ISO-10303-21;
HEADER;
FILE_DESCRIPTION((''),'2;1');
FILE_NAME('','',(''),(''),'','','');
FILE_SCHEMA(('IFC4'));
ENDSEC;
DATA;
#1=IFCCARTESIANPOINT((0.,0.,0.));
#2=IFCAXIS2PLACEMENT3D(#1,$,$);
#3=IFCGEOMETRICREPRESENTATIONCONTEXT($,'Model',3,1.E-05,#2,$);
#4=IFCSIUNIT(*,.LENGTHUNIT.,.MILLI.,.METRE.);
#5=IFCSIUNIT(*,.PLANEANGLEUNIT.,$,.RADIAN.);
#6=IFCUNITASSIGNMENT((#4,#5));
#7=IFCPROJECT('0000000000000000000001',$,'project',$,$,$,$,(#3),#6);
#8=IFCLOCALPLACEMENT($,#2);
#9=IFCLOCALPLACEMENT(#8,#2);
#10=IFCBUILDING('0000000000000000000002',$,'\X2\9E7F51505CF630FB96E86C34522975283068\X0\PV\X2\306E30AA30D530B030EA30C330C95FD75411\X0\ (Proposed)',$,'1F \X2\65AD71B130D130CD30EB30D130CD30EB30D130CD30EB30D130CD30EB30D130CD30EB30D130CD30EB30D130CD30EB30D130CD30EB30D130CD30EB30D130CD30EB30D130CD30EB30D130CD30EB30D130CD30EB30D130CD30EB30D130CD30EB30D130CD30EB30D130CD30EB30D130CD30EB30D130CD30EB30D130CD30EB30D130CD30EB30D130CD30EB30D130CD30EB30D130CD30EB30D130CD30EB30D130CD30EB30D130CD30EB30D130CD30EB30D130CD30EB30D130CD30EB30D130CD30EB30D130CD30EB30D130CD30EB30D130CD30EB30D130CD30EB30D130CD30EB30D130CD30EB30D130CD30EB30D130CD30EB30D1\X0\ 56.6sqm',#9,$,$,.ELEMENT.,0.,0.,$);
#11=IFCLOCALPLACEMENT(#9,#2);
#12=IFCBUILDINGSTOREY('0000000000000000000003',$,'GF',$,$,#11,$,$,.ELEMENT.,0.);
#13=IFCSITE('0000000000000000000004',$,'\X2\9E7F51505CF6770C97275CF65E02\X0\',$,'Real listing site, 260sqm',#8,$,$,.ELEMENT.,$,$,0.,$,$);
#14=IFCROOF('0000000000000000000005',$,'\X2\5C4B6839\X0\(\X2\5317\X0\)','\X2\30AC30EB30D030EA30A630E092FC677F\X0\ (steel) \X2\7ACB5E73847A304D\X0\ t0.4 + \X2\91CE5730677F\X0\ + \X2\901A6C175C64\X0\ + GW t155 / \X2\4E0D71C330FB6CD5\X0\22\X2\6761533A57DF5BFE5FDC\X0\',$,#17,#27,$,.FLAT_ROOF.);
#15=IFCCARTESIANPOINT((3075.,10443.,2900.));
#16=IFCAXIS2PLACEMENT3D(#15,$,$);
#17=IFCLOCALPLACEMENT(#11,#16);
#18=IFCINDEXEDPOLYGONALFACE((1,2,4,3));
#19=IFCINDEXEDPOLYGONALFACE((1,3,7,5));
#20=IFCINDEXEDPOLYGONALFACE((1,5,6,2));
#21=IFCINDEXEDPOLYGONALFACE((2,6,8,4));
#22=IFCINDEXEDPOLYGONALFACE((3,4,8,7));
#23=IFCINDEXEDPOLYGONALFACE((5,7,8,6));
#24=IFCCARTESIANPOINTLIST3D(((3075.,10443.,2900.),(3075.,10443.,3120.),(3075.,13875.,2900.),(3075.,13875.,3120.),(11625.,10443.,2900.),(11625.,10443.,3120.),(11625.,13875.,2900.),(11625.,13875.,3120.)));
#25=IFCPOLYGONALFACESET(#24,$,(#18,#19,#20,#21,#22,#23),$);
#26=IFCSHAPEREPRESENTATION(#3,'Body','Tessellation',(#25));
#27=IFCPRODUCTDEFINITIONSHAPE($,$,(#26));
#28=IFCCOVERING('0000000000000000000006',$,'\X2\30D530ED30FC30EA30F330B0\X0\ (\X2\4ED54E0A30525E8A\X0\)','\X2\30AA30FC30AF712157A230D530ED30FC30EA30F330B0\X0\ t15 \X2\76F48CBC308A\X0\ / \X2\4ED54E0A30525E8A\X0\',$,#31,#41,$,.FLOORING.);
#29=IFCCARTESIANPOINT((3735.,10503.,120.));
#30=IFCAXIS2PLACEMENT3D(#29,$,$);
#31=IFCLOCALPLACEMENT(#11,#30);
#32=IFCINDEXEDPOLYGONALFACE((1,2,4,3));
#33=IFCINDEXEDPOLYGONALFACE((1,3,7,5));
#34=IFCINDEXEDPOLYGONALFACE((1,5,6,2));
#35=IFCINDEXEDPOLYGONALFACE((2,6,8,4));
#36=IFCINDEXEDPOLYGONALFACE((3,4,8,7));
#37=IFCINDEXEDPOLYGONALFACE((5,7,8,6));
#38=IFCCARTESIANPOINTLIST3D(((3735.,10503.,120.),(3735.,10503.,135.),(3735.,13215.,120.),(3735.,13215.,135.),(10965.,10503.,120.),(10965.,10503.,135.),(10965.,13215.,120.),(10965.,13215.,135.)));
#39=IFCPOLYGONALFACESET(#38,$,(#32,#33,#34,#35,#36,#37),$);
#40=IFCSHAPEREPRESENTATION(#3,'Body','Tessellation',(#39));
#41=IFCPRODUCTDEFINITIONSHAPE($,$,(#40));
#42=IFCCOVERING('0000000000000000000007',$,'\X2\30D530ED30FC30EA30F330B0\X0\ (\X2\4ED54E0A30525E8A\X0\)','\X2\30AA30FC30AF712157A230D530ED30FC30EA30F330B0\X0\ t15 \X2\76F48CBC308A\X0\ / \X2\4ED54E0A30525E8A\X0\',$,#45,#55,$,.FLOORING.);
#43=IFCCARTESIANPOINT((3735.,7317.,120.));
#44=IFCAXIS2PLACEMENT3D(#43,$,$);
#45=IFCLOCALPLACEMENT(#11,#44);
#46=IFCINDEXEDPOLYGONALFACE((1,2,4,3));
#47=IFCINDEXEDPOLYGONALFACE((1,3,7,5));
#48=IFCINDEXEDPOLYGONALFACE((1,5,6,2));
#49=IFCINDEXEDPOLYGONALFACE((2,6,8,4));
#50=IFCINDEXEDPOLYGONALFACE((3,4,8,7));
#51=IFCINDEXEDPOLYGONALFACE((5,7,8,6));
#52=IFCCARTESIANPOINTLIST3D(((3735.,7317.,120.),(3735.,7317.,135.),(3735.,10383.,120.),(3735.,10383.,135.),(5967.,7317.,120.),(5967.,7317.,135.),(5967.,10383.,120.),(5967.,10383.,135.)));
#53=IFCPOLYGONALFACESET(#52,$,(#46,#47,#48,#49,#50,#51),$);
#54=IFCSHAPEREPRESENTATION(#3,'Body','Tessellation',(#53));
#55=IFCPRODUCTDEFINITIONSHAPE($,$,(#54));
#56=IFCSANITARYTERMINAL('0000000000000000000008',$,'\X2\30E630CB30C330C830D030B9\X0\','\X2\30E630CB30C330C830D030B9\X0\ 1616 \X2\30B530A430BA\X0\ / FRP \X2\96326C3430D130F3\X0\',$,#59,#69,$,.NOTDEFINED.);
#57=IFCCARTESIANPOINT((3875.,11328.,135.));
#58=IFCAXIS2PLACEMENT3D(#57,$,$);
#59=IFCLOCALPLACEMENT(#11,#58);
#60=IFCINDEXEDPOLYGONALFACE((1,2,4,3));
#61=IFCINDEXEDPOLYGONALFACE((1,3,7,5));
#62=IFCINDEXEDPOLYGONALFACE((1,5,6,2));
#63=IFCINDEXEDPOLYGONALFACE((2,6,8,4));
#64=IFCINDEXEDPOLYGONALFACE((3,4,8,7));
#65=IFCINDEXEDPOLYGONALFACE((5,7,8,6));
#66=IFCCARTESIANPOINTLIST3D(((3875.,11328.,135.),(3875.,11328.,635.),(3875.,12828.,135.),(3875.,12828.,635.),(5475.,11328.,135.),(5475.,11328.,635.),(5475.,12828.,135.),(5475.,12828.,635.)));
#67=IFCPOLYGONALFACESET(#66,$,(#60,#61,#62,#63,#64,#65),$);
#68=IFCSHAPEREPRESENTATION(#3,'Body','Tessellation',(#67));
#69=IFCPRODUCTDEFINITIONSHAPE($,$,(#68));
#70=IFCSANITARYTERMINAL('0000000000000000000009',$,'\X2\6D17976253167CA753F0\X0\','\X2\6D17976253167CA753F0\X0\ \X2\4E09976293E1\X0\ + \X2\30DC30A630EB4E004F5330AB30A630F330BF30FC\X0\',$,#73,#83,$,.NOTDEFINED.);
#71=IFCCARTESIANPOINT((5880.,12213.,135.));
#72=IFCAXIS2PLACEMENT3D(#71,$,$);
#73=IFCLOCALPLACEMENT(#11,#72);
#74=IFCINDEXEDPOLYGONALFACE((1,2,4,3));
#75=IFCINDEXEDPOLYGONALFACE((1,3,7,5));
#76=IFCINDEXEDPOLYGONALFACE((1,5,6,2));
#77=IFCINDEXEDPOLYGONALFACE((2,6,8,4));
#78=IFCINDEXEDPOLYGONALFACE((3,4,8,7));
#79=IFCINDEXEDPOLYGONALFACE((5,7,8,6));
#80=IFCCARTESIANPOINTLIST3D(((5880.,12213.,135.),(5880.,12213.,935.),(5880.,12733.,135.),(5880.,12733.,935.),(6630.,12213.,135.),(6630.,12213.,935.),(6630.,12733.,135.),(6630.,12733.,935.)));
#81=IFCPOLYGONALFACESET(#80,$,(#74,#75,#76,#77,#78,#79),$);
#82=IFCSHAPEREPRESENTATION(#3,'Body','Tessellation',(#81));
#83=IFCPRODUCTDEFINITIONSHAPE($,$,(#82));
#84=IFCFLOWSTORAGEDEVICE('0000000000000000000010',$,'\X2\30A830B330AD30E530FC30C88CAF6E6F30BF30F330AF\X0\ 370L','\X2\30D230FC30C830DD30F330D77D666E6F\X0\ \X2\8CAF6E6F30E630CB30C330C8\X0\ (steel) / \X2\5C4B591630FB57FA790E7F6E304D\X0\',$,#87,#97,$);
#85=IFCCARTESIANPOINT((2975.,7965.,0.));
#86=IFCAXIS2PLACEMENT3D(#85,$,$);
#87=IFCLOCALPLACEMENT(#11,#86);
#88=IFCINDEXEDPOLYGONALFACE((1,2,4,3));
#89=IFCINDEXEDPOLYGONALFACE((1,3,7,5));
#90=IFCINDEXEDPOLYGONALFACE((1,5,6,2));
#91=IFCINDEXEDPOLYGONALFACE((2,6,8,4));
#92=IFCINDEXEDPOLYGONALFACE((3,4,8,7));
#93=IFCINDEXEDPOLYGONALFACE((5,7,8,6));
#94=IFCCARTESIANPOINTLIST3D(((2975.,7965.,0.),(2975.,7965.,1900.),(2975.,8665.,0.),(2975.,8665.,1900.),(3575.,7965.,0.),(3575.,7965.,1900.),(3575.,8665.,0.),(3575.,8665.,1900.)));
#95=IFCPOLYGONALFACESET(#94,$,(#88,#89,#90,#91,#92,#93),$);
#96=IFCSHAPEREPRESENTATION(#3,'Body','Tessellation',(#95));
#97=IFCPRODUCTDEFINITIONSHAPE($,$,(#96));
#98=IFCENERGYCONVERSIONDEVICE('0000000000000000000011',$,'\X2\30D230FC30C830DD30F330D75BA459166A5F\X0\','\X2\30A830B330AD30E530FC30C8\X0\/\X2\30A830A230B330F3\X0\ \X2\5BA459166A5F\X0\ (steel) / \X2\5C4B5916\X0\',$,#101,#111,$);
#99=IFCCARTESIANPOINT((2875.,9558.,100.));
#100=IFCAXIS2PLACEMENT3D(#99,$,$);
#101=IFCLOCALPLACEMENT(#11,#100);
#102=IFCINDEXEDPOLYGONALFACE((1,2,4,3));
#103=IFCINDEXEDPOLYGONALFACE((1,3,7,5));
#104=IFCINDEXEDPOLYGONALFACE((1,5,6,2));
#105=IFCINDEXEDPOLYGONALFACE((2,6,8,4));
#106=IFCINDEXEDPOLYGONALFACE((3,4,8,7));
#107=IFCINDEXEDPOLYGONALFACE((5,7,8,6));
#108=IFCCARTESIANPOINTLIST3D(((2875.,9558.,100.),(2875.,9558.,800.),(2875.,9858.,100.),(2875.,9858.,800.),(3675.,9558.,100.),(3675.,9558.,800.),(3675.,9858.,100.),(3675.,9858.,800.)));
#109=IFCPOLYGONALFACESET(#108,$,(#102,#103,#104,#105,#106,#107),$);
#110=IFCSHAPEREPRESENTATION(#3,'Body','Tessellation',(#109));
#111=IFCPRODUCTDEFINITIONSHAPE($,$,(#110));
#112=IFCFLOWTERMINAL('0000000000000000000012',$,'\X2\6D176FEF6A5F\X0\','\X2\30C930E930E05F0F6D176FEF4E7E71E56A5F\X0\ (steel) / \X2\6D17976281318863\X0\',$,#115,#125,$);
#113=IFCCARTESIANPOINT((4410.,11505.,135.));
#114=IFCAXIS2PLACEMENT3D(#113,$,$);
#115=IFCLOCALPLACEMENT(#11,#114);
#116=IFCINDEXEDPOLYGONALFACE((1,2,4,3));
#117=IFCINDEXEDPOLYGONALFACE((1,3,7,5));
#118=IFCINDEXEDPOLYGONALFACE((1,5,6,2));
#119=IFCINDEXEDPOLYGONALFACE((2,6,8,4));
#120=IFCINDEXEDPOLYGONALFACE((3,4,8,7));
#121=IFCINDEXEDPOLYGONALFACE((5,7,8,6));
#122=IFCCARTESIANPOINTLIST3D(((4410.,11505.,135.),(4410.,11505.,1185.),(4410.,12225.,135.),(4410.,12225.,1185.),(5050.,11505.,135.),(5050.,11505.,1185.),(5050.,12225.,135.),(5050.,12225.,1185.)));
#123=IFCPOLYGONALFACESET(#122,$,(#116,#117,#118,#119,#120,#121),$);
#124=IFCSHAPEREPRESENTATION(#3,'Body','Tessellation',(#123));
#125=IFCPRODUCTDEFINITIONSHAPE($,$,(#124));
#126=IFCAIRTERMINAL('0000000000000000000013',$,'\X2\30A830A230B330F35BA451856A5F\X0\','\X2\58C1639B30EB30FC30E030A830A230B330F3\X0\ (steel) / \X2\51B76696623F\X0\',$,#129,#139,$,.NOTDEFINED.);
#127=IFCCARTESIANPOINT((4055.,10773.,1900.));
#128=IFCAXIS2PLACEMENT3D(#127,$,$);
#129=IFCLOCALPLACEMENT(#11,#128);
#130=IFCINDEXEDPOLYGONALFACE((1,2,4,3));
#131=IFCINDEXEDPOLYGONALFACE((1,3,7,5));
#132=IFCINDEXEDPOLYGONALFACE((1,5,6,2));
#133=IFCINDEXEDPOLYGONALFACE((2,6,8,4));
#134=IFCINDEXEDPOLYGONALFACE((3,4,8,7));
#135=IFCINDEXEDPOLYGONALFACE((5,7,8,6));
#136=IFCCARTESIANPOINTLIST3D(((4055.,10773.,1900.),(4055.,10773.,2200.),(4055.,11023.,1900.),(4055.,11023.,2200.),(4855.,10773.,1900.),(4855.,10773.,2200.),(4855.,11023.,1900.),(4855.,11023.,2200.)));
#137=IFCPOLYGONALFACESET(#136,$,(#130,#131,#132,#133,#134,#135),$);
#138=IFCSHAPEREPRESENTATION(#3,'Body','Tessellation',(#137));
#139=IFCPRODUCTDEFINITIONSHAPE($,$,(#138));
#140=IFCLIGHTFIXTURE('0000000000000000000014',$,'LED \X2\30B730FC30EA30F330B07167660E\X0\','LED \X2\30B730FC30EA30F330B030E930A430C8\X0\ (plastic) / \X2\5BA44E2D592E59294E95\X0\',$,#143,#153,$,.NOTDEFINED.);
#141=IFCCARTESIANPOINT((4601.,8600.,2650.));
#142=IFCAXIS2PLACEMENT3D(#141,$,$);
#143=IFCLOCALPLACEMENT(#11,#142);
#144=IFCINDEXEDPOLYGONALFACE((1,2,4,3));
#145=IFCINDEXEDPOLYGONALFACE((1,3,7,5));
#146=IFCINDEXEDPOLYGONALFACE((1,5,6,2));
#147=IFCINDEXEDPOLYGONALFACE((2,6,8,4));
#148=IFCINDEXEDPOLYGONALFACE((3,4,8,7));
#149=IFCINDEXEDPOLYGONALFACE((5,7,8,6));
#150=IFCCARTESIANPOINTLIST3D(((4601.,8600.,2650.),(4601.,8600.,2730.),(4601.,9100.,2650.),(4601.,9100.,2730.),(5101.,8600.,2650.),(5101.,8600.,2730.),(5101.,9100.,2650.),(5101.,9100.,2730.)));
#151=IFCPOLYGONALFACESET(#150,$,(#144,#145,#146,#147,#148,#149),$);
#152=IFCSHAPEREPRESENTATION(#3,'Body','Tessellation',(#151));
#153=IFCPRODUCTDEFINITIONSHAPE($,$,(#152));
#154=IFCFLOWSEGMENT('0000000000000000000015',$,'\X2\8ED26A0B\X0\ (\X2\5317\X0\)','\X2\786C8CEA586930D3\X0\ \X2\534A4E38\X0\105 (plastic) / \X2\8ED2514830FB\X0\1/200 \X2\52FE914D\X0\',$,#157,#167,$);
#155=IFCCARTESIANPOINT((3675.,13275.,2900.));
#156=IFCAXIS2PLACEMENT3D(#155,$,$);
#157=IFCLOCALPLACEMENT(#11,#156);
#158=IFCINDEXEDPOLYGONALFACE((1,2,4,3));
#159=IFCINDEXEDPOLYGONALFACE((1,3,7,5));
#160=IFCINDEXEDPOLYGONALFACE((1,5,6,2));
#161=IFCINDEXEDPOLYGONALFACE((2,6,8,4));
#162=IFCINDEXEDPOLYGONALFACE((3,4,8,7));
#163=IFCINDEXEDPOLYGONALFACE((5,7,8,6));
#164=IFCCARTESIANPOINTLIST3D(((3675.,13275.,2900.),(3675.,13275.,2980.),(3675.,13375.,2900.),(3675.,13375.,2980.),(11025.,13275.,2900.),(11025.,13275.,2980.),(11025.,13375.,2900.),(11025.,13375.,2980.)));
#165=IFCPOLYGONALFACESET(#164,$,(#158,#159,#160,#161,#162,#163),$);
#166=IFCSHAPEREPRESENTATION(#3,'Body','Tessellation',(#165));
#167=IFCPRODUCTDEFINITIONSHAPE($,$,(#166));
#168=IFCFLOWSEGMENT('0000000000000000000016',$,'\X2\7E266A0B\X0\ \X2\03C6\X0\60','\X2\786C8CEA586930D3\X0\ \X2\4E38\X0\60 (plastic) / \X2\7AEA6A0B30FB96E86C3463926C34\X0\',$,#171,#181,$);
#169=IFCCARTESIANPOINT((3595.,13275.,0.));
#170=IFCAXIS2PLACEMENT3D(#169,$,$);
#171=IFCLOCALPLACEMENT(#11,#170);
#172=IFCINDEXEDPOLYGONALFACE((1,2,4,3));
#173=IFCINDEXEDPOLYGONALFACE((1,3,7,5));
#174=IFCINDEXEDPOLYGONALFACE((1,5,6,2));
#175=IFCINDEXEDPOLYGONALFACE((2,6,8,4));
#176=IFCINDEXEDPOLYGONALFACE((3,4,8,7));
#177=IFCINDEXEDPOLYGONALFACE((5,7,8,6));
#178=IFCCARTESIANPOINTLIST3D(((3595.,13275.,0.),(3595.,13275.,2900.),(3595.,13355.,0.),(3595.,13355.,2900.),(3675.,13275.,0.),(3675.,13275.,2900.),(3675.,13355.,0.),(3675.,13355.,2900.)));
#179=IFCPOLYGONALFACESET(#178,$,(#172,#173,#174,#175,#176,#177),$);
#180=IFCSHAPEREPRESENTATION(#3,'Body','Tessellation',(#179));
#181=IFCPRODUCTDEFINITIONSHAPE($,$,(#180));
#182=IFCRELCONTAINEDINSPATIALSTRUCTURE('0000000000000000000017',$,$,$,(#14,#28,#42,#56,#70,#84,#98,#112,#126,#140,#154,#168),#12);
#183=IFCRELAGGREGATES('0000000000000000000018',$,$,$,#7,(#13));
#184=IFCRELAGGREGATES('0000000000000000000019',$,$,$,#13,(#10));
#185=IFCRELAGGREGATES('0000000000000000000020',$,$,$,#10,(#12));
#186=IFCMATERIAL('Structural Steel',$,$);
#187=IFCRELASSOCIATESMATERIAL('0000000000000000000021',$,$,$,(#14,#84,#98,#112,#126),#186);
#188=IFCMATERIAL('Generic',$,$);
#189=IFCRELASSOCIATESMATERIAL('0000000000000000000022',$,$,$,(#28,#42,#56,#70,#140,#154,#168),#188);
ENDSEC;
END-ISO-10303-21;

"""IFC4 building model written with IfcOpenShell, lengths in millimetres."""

from ifc_helpers import new_model, si_unit, frame, frame_2d, origin, place, context, project, spatial, rectangle, extrude, material, element, save


model = new_model("IFC4")

# Units and contexts
model_context = context("Model", 3, precision=1e-05, world=origin())
ifc_project = project(units=[si_unit("LENGTHUNIT", "METRE", prefix="MILLI"), si_unit("PLANEANGLEUNIT", "RADIAN")], contexts=[model_context])

# Site, building, storey
site_placement = place(None, origin())
site = spatial("IfcSite", under=ifc_project, at=site_placement, Name="鹿児島県霧島市", ObjectType="Real listing site, 260sqm", CompositionType="ELEMENT", RefElevation=0.0)
building_placement = place(site_placement, origin())
building = spatial("IfcBuilding", under=site, at=building_placement, Name="鹿児島・雨水利用とPVのオフグリッド志向 (Proposed)", ObjectType="1F 断熱パネルパネルパネルパネルパネルパネルパネルパネルパネルパネルパネルパネルパネルパネルパネルパネルパネルパネルパネルパネルパネルパネルパネルパネルパネルパネルパネルパネルパネルパネルパネルパネルパネルパネルパネルパネルパネルパネルパネルパ 56.6sqm", CompositionType="ELEMENT", ElevationOfRefHeight=0.0, ElevationOfTerrain=0.0)
storey_placement = place(building_placement, origin())
storey = spatial("IfcBuildingStorey", under=building, at=storey_placement, Name="GF", CompositionType="ELEMENT", Elevation=0.0)

# Roof
ifc_material_1 = material(Name="Structural Steel")
roof_placement = place(storey_placement, frame((3075.0, 10443.0, 2900.0)))
element("IfcRoof", 1, at=roof_placement, inside=storey, material=ifc_material_1, Name="屋根(北)", Description="ガルバリウム鋼板 (steel) 立平葺き t0.4 + 野地板 + 通気層 + GW t155 / 不燃・法22条区域対応", PredefinedType="FLAT_ROOF", context=model_context, shape_type="SweptSolid", body=[
    extrude(rectangle(XDim=8550.0, YDim=3432.0, at=frame_2d((4275.0, 1716.0))), frame((3075.0, 10443.0, 2900.0)), (0.0, 0.0, 1.0), 220.0),
])

# Coverings
ifc_material_2 = material(Name="Generic")
covering_1_placement = place(storey_placement, frame((3735.0, 10503.0, 120.0)))
element("IfcCovering", 2, at=covering_1_placement, inside=storey, material=ifc_material_2, Name="フローリング (仕上げ床)", Description="オーク無垢フローリング t15 直貼り / 仕上げ床", PredefinedType="FLOORING", context=model_context, shape_type="SweptSolid", body=[
    extrude(rectangle(XDim=7230.0, YDim=2712.0, at=frame_2d((3615.0, 1356.0))), frame((3735.0, 10503.0, 120.0)), (0.0, 0.0, 1.0), 15.0),
])
covering_2_placement = place(storey_placement, frame((3735.0, 7317.0, 120.0)))
element("IfcCovering", 3, at=covering_2_placement, inside=storey, material=ifc_material_2, Name="フローリング (仕上げ床)", Description="オーク無垢フローリング t15 直貼り / 仕上げ床", PredefinedType="FLOORING", context=model_context, shape_type="SweptSolid", body=[
    extrude(rectangle(XDim=2232.0, YDim=3066.0, at=frame_2d((1116.0, 1533.0))), frame((3735.0, 7317.0, 120.0)), (0.0, 0.0, 1.0), 15.0),
])

# Sanitary terminals
sanitary_terminal_1_placement = place(storey_placement, frame((3875.0, 11328.0, 135.0)))
element("IfcSanitaryTerminal", 4, at=sanitary_terminal_1_placement, inside=storey, material=ifc_material_2, Name="ユニットバス", Description="ユニットバス 1616 サイズ / FRP 防水パン", PredefinedType="NOTDEFINED", context=model_context, shape_type="SweptSolid", body=[
    extrude(rectangle(XDim=1600.0, YDim=1500.0, at=frame_2d((800.0, 750.0))), frame((3875.0, 11328.0, 135.0)), (0.0, 0.0, 1.0), 500.0),
])
sanitary_terminal_2_placement = place(storey_placement, frame((5880.0, 12213.0, 135.0)))
element("IfcSanitaryTerminal", 5, at=sanitary_terminal_2_placement, inside=storey, material=ifc_material_2, Name="洗面化粧台", Description="洗面化粧台 三面鏡 + ボウル一体カウンター", PredefinedType="NOTDEFINED", context=model_context, shape_type="SweptSolid", body=[
    extrude(rectangle(XDim=750.0, YDim=520.0, at=frame_2d((375.0, 260.0))), frame((5880.0, 12213.0, 135.0)), (0.0, 0.0, 1.0), 800.0),
])

# Flow storage device
flow_storage_device_placement = place(storey_placement, frame((2975.0, 7965.0, 0.0)))
element("IfcFlowStorageDevice", 6, at=flow_storage_device_placement, inside=storey, material=ifc_material_1, Name="エコキュート貯湯タンク 370L", Description="ヒートポンプ給湯 貯湯ユニット (steel) / 屋外・基礎置き", context=model_context, shape_type="SweptSolid", body=[
    extrude(rectangle(XDim=600.0, YDim=700.0, at=frame_2d((300.0, 350.0))), frame((2975.0, 7965.0, 0.0)), (0.0, 0.0, 1.0), 1900.0),
])

# Energy conversion device
energy_conversion_device_placement = place(storey_placement, frame((2875.0, 9558.0, 100.0)))
element("IfcEnergyConversionDevice", 7, at=energy_conversion_device_placement, inside=storey, material=ifc_material_1, Name="ヒートポンプ室外機", Description="エコキュート/エアコン 室外機 (steel) / 屋外", context=model_context, shape_type="SweptSolid", body=[
    extrude(rectangle(XDim=800.0, YDim=300.0, at=frame_2d((400.0, 150.0))), frame((2875.0, 9558.0, 100.0)), (0.0, 0.0, 1.0), 700.0),
])

# Flow terminal
flow_terminal_placement = place(storey_placement, frame((4410.0, 11505.0, 135.0)))
element("IfcFlowTerminal", 8, at=flow_terminal_placement, inside=storey, material=ifc_material_1, Name="洗濯機", Description="ドラム式洗濯乾燥機 (steel) / 洗面脱衣", context=model_context, shape_type="SweptSolid", body=[
    extrude(rectangle(XDim=640.0, YDim=720.0, at=frame_2d((320.0, 360.0))), frame((4410.0, 11505.0, 135.0)), (0.0, 0.0, 1.0), 1050.0),
])

# Air terminal
air_terminal_placement = place(storey_placement, frame((4055.0, 10773.0, 1900.0)))
element("IfcAirTerminal", 9, at=air_terminal_placement, inside=storey, material=ifc_material_1, Name="エアコン室内機", Description="壁掛ルームエアコン (steel) / 冷暖房", PredefinedType="NOTDEFINED", context=model_context, shape_type="SweptSolid", body=[
    extrude(rectangle(XDim=800.0, YDim=250.0, at=frame_2d((400.0, 125.0))), frame((4055.0, 10773.0, 1900.0)), (0.0, 0.0, 1.0), 300.0),
])

# Light fixture
light_fixture_placement = place(storey_placement, frame((4601.0, 8600.0, 2650.0)))
element("IfcLightFixture", 10, at=light_fixture_placement, inside=storey, material=ifc_material_2, Name="LED シーリング照明", Description="LED シーリングライト (plastic) / 室中央天井", PredefinedType="NOTDEFINED", context=model_context, shape_type="SweptSolid", body=[
    extrude(rectangle(XDim=500.0, YDim=500.0, at=frame_2d((250.0, 250.0))), frame((4601.0, 8600.0, 2650.0)), (0.0, 0.0, 1.0), 80.0),
])

# Flow segments
flow_segment_1_placement = place(storey_placement, frame((3675.0, 13275.0, 2900.0)))
element("IfcFlowSegment", 11, at=flow_segment_1_placement, inside=storey, material=ifc_material_2, Name="軒樋 (北)", Description="硬質塩ビ 半丸105 (plastic) / 軒先・1/200 勾配", context=model_context, shape_type="SweptSolid", body=[
    extrude(rectangle(XDim=7350.0, YDim=100.0, at=frame_2d((3675.0, 50.0))), frame((3675.0, 13275.0, 2900.0)), (0.0, 0.0, 1.0), 80.0),
])
flow_segment_2_placement = place(storey_placement, frame((3595.0, 13275.0, 0.0)))
element("IfcFlowSegment", 12, at=flow_segment_2_placement, inside=storey, material=ifc_material_2, Name="縦樋 φ60", Description="硬質塩ビ 丸60 (plastic) / 竪樋・雨水排水", context=model_context, shape_type="SweptSolid", body=[
    extrude(rectangle(XDim=80.0, YDim=80.0, at=frame_2d((40.0, 40.0))), frame((3595.0, 13275.0, 0.0)), (0.0, 0.0, 1.0), 2900.0),
])

save(model, "model.ifc")
